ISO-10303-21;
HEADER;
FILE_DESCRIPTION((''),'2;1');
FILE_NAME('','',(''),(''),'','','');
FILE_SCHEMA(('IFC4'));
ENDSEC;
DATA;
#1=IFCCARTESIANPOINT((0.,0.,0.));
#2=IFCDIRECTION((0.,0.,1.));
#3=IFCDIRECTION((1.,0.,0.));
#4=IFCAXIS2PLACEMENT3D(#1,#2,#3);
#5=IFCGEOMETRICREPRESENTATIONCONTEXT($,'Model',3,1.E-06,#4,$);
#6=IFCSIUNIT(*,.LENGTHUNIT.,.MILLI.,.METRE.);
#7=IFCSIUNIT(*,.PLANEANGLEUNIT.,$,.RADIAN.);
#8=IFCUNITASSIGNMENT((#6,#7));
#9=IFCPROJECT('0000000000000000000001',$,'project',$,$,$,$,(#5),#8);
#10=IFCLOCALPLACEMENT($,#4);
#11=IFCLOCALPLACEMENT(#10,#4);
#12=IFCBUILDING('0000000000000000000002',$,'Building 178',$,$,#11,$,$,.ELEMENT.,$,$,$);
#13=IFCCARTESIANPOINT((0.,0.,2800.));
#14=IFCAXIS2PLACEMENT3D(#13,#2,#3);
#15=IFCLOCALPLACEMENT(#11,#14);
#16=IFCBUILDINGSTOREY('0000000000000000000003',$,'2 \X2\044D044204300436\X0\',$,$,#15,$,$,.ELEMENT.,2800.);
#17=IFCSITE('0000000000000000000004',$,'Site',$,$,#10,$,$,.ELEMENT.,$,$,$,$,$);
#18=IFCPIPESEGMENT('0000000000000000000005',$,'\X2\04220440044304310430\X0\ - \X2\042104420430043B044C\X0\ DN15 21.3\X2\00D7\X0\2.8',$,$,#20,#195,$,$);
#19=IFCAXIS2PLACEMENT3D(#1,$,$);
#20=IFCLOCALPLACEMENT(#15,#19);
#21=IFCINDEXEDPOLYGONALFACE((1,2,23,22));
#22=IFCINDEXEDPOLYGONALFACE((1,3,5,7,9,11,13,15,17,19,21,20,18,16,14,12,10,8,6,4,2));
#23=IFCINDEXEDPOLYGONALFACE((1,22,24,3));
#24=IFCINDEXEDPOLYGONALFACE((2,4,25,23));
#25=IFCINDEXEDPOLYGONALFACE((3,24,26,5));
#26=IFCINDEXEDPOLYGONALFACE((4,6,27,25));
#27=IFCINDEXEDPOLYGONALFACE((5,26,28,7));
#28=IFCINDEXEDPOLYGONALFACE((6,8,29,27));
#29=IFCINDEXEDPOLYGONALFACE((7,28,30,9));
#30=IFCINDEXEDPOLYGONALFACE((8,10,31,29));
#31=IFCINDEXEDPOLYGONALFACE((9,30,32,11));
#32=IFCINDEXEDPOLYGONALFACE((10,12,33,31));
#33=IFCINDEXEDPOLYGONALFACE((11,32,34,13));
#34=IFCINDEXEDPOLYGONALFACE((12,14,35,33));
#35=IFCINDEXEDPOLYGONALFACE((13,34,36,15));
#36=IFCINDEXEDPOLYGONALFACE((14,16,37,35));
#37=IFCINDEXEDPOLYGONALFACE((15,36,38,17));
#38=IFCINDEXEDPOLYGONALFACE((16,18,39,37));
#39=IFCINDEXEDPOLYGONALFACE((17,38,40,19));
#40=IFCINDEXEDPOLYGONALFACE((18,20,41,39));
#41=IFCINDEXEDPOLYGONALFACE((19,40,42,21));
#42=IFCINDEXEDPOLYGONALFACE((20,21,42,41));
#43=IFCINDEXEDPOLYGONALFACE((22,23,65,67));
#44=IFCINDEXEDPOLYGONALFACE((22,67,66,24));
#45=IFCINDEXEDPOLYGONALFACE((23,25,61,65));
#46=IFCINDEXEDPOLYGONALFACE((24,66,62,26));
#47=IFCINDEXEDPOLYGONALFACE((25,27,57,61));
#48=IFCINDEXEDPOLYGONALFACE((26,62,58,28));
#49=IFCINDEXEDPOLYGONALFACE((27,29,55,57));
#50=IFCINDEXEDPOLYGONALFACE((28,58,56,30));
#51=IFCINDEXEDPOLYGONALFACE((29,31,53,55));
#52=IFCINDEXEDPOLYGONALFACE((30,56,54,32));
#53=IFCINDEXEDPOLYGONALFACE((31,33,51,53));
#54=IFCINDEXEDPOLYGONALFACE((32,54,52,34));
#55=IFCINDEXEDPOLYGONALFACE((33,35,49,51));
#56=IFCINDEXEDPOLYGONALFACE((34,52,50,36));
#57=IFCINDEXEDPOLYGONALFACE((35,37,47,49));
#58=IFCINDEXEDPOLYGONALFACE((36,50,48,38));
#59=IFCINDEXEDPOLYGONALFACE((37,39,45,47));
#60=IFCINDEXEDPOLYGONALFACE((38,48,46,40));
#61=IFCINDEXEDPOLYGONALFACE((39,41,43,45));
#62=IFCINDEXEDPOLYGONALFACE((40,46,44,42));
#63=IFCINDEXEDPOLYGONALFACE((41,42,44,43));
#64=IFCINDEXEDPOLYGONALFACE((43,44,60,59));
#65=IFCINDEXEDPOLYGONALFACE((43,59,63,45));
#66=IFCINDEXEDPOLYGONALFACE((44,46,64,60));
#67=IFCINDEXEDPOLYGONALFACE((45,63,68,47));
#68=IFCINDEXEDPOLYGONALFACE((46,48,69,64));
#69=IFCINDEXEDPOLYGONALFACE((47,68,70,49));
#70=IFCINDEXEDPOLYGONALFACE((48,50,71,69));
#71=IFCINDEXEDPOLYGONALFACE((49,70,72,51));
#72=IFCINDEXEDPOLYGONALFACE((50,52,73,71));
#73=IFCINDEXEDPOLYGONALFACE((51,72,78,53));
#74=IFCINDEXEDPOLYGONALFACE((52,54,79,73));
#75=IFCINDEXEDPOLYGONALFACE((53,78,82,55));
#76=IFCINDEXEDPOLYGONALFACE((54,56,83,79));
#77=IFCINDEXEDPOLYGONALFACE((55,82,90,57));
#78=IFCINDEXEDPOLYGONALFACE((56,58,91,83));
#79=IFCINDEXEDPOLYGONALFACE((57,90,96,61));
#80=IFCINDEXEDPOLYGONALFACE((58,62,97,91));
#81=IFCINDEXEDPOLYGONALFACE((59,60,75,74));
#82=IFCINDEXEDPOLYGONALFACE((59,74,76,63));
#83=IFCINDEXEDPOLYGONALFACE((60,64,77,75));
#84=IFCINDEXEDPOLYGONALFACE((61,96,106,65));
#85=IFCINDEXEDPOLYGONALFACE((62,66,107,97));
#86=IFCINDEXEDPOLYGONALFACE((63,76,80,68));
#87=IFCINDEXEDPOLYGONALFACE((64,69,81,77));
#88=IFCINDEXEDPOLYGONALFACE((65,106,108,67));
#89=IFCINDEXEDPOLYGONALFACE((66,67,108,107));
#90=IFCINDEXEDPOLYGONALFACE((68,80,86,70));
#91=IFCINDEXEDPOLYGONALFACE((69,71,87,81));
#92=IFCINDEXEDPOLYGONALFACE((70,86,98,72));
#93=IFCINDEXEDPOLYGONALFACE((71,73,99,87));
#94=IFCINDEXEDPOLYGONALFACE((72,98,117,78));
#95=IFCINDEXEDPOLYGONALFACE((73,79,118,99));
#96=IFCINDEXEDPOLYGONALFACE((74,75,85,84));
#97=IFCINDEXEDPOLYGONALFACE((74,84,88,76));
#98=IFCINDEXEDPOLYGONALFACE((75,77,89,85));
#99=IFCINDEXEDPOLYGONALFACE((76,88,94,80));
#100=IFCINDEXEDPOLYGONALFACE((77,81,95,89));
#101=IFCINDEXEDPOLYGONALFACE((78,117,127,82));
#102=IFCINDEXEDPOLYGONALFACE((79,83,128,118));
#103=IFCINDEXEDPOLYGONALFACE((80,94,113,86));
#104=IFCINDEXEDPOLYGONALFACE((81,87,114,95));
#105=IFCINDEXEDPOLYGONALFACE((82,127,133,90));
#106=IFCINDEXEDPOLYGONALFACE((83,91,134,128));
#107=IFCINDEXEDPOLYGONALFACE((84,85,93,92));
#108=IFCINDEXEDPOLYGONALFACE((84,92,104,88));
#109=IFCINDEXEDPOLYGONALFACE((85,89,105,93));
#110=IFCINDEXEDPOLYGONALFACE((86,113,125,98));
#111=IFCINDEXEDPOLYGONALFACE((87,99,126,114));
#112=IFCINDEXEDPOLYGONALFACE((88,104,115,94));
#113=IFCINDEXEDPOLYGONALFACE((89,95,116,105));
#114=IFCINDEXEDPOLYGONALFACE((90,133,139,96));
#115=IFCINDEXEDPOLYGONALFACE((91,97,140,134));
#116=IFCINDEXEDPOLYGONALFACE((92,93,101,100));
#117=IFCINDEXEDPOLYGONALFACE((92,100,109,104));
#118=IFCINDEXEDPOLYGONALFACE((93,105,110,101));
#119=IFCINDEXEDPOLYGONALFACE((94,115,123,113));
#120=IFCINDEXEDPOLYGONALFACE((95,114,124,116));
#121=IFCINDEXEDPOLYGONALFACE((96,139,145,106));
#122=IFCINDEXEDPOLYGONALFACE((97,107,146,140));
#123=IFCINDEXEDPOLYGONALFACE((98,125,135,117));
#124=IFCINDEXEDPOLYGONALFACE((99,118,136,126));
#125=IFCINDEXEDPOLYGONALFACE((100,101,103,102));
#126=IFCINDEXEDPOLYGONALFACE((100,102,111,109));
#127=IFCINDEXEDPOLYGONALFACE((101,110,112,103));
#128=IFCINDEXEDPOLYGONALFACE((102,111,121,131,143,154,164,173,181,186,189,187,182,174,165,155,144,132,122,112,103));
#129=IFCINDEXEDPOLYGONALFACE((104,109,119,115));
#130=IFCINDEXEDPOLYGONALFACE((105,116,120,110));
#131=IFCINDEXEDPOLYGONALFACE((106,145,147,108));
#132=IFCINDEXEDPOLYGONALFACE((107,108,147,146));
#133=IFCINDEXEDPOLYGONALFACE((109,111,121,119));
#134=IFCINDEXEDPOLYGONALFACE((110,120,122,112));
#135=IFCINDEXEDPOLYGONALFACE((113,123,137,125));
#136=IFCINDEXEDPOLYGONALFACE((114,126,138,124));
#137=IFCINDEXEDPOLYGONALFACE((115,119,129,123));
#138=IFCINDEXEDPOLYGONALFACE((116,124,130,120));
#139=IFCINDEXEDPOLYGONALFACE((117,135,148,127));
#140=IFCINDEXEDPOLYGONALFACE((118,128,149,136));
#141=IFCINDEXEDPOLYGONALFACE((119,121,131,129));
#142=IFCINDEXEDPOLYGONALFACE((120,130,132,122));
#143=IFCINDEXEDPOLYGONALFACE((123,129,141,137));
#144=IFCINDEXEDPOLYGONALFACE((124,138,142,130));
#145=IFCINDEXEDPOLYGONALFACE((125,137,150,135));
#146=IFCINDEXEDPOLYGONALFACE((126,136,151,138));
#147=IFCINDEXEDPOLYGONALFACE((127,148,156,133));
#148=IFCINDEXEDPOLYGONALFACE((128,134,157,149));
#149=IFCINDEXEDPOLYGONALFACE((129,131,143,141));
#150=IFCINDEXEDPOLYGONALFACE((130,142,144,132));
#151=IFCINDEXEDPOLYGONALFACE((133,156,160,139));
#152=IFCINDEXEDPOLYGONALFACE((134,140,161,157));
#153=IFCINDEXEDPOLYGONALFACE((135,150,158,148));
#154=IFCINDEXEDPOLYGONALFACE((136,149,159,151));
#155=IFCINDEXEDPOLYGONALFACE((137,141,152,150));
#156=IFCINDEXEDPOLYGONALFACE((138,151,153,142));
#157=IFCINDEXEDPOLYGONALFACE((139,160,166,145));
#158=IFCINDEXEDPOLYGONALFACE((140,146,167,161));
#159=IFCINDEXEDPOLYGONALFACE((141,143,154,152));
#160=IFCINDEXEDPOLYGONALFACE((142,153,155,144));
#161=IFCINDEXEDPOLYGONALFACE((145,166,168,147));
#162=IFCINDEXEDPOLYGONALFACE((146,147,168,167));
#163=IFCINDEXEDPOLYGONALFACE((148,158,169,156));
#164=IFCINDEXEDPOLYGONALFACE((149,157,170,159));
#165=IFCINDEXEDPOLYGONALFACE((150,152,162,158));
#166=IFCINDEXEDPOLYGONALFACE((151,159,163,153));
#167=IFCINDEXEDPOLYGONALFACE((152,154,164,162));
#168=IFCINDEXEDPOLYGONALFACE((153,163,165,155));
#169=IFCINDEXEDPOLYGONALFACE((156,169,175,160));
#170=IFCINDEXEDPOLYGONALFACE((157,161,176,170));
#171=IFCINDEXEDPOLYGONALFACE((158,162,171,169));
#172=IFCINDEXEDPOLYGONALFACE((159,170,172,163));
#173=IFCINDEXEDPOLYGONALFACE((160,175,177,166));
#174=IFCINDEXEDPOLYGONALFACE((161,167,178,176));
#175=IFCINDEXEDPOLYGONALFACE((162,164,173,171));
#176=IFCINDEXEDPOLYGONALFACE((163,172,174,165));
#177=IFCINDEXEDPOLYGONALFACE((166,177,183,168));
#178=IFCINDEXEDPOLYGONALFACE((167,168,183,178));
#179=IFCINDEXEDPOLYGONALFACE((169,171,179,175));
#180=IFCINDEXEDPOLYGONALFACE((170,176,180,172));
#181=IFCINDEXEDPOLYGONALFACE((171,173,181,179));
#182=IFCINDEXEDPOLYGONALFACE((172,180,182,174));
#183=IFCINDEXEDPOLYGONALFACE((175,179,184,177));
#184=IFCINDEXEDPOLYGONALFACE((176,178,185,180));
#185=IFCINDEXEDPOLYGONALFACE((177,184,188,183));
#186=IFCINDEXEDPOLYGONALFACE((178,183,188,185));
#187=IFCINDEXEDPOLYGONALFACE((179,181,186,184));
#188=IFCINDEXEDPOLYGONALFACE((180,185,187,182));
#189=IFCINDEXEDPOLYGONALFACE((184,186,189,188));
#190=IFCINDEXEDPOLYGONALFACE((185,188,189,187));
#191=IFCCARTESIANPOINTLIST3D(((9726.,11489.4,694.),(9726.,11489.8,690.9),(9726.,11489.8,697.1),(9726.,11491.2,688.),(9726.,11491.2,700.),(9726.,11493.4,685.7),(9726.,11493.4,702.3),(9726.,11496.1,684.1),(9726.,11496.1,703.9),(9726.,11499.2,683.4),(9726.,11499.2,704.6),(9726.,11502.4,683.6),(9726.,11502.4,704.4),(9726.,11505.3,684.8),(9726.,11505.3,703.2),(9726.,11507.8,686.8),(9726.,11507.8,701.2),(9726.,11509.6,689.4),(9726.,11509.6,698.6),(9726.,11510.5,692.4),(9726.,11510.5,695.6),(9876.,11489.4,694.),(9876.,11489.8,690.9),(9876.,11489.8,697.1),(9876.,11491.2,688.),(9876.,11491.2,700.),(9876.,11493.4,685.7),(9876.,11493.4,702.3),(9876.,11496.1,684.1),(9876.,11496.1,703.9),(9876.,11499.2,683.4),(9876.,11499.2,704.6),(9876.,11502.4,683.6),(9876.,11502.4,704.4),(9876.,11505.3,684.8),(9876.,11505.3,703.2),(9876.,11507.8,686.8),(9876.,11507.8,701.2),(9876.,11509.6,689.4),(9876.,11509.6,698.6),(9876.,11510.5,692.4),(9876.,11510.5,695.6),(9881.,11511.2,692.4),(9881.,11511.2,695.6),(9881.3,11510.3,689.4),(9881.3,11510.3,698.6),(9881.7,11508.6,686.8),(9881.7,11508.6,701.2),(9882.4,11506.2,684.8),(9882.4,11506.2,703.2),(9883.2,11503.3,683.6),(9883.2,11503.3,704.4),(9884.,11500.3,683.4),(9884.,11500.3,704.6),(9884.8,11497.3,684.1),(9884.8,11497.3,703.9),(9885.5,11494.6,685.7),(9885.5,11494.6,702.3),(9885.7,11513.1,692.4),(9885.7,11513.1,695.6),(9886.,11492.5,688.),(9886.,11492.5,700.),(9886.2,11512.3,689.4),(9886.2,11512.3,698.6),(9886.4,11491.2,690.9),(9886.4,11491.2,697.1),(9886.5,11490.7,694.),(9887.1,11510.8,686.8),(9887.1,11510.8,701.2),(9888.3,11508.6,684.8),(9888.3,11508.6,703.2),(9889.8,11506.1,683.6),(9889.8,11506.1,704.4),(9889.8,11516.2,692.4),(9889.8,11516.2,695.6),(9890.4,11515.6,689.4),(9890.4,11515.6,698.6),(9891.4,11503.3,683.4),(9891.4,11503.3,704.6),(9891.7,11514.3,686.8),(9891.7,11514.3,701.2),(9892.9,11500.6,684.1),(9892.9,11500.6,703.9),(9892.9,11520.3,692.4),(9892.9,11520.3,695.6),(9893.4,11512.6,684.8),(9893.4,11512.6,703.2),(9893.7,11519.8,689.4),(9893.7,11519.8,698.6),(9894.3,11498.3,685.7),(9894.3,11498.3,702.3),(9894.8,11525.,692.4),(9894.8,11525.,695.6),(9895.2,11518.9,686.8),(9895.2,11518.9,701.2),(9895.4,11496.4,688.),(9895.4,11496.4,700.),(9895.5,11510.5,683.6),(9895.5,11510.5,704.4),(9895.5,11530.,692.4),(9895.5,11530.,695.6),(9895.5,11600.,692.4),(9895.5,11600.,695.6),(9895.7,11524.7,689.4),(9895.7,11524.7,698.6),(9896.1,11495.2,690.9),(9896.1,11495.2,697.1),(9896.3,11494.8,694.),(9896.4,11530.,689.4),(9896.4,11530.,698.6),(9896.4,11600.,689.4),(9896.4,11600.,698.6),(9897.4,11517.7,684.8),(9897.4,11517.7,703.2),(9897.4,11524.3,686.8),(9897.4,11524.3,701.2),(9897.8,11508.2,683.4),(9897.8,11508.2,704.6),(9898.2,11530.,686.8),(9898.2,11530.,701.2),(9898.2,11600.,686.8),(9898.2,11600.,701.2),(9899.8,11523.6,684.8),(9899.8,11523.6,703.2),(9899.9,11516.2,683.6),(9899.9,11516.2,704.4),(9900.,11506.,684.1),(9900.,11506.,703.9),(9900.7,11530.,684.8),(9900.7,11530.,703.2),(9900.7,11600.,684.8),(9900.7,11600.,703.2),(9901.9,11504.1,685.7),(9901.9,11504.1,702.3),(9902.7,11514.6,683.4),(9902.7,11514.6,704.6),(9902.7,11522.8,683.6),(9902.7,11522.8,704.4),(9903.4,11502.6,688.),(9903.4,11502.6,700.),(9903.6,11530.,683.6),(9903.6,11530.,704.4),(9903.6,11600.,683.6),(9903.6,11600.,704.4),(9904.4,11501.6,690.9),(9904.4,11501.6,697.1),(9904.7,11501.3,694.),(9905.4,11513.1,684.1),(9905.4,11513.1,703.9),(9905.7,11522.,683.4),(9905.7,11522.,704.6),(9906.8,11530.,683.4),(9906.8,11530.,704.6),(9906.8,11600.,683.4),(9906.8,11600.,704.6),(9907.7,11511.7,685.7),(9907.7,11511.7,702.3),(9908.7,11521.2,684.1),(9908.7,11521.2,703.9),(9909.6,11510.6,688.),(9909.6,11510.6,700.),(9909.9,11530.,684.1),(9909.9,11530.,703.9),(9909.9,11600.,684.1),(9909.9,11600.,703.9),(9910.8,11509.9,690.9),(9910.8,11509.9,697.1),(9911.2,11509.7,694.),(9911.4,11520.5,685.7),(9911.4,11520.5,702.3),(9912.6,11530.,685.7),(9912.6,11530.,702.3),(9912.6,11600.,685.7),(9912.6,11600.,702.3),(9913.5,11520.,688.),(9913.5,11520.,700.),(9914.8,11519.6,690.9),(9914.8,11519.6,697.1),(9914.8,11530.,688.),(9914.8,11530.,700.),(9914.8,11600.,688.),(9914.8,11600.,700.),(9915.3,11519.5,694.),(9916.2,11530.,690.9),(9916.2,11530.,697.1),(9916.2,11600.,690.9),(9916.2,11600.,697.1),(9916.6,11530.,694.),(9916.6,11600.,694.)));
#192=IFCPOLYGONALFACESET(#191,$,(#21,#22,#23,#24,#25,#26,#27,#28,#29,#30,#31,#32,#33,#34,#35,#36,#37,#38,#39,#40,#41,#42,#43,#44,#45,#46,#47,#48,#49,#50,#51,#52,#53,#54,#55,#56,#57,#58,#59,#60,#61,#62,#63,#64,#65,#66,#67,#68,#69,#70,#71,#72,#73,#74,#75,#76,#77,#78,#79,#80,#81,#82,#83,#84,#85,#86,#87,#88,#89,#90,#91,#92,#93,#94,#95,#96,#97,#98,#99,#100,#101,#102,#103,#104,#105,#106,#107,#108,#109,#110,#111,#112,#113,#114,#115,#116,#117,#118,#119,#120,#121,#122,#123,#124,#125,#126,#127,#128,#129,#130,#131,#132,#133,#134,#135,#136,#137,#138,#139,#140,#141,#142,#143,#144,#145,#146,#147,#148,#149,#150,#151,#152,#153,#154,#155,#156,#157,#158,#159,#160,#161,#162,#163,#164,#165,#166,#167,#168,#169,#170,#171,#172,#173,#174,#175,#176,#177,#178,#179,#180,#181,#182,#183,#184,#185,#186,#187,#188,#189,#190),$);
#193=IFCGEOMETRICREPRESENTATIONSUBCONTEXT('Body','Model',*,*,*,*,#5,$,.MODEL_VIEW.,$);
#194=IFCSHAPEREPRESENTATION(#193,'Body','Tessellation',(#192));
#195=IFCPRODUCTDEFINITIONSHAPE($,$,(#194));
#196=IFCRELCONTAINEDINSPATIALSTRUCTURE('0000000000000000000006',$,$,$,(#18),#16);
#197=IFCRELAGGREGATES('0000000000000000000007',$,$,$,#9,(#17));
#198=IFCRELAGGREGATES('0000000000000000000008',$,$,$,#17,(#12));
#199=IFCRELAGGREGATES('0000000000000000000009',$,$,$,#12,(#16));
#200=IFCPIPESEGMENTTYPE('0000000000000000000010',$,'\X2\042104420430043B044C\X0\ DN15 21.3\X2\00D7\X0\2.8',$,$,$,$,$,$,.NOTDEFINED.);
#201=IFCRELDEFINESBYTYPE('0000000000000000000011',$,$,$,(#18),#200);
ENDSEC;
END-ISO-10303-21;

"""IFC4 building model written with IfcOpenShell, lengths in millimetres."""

from ifc_helpers import new_model, entity, si_unit, frame, origin_with_axes, place, context, subcontext, project, spatial, source, transform, mapped, type_object, element, save


model = new_model("IFC4")

# Units and contexts
model_context = context("Model", 3, precision=1e-06, world=origin_with_axes())
body_context = subcontext(model_context, "Body", "Model", "MODEL_VIEW")
ifc_project = project(units=[si_unit("LENGTHUNIT", "METRE", prefix="MILLI"), si_unit("PLANEANGLEUNIT", "RADIAN")], contexts=[model_context])

# Site, building, storey
site_placement = place(None, origin_with_axes())
site = spatial("IfcSite", under=ifc_project, at=site_placement, Name="Site", CompositionType="ELEMENT")
building_placement = place(site_placement, origin_with_axes())
building = spatial("IfcBuilding", under=site, at=building_placement, Name="Building 178", CompositionType="ELEMENT")
storey_placement = place(building_placement, frame((0.0, 0.0, 2800.0), z_axis=(0.0, 0.0, 1.0), x_axis=(1.0, 0.0, 0.0)))
storey = spatial("IfcBuildingStorey", under=building, at=storey_placement, Name="2 этаж", CompositionType="ELEMENT", Elevation=2800.0)

# Pipe segment
pipe_segment_type = type_object("IfcPipeSegmentType", Name="Сталь DN15 21.3×2.8", PredefinedType="NOTDEFINED")
shared_shape_1 = source(origin_with_axes(), body_context, "Body", "AdvancedSweptSolid", [
    entity("IfcSweptDiskSolid", entity("IfcIndexedPolyCurve", entity("IfcCartesianPointList3D", [[0.0, 0.0, 0.0], [0.0, 0.0, -70.0], [8.8, 0.0, -91.2], [30.0, 0.0, -100.0], [180.0, 0.0, -100.0]]), [entity("IfcLineIndex", [1, 2]), entity("IfcArcIndex", [2, 3, 4]), entity("IfcLineIndex", [4, 5])]), 10.7),
])
for number, where, z_axis, x_axis, name in (
    (1, (9906.0, 11600.0, 694.0), (0.0, 1.0, 0.0), (-1.0, 0.0, 0.0), "Труба - Сталь DN15 21.3×2.8"),
):
    element("IfcPipeSegment", number, at=place(storey_placement, frame(where, z_axis=z_axis, x_axis=x_axis)), inside=storey, type_object=pipe_segment_type, Name=name, context=body_context, shape_type="MappedRepresentation", body=[
        mapped(shared_shape_1, transform((0.0, 0.0, 0.0), x_axis=(1.0, 0.0, 0.0), y_axis=(0.0, 1.0, 0.0), z_axis=(0.0, 0.0, 1.0), scale=1.0)),
    ])

save(model, "model.ifc")
